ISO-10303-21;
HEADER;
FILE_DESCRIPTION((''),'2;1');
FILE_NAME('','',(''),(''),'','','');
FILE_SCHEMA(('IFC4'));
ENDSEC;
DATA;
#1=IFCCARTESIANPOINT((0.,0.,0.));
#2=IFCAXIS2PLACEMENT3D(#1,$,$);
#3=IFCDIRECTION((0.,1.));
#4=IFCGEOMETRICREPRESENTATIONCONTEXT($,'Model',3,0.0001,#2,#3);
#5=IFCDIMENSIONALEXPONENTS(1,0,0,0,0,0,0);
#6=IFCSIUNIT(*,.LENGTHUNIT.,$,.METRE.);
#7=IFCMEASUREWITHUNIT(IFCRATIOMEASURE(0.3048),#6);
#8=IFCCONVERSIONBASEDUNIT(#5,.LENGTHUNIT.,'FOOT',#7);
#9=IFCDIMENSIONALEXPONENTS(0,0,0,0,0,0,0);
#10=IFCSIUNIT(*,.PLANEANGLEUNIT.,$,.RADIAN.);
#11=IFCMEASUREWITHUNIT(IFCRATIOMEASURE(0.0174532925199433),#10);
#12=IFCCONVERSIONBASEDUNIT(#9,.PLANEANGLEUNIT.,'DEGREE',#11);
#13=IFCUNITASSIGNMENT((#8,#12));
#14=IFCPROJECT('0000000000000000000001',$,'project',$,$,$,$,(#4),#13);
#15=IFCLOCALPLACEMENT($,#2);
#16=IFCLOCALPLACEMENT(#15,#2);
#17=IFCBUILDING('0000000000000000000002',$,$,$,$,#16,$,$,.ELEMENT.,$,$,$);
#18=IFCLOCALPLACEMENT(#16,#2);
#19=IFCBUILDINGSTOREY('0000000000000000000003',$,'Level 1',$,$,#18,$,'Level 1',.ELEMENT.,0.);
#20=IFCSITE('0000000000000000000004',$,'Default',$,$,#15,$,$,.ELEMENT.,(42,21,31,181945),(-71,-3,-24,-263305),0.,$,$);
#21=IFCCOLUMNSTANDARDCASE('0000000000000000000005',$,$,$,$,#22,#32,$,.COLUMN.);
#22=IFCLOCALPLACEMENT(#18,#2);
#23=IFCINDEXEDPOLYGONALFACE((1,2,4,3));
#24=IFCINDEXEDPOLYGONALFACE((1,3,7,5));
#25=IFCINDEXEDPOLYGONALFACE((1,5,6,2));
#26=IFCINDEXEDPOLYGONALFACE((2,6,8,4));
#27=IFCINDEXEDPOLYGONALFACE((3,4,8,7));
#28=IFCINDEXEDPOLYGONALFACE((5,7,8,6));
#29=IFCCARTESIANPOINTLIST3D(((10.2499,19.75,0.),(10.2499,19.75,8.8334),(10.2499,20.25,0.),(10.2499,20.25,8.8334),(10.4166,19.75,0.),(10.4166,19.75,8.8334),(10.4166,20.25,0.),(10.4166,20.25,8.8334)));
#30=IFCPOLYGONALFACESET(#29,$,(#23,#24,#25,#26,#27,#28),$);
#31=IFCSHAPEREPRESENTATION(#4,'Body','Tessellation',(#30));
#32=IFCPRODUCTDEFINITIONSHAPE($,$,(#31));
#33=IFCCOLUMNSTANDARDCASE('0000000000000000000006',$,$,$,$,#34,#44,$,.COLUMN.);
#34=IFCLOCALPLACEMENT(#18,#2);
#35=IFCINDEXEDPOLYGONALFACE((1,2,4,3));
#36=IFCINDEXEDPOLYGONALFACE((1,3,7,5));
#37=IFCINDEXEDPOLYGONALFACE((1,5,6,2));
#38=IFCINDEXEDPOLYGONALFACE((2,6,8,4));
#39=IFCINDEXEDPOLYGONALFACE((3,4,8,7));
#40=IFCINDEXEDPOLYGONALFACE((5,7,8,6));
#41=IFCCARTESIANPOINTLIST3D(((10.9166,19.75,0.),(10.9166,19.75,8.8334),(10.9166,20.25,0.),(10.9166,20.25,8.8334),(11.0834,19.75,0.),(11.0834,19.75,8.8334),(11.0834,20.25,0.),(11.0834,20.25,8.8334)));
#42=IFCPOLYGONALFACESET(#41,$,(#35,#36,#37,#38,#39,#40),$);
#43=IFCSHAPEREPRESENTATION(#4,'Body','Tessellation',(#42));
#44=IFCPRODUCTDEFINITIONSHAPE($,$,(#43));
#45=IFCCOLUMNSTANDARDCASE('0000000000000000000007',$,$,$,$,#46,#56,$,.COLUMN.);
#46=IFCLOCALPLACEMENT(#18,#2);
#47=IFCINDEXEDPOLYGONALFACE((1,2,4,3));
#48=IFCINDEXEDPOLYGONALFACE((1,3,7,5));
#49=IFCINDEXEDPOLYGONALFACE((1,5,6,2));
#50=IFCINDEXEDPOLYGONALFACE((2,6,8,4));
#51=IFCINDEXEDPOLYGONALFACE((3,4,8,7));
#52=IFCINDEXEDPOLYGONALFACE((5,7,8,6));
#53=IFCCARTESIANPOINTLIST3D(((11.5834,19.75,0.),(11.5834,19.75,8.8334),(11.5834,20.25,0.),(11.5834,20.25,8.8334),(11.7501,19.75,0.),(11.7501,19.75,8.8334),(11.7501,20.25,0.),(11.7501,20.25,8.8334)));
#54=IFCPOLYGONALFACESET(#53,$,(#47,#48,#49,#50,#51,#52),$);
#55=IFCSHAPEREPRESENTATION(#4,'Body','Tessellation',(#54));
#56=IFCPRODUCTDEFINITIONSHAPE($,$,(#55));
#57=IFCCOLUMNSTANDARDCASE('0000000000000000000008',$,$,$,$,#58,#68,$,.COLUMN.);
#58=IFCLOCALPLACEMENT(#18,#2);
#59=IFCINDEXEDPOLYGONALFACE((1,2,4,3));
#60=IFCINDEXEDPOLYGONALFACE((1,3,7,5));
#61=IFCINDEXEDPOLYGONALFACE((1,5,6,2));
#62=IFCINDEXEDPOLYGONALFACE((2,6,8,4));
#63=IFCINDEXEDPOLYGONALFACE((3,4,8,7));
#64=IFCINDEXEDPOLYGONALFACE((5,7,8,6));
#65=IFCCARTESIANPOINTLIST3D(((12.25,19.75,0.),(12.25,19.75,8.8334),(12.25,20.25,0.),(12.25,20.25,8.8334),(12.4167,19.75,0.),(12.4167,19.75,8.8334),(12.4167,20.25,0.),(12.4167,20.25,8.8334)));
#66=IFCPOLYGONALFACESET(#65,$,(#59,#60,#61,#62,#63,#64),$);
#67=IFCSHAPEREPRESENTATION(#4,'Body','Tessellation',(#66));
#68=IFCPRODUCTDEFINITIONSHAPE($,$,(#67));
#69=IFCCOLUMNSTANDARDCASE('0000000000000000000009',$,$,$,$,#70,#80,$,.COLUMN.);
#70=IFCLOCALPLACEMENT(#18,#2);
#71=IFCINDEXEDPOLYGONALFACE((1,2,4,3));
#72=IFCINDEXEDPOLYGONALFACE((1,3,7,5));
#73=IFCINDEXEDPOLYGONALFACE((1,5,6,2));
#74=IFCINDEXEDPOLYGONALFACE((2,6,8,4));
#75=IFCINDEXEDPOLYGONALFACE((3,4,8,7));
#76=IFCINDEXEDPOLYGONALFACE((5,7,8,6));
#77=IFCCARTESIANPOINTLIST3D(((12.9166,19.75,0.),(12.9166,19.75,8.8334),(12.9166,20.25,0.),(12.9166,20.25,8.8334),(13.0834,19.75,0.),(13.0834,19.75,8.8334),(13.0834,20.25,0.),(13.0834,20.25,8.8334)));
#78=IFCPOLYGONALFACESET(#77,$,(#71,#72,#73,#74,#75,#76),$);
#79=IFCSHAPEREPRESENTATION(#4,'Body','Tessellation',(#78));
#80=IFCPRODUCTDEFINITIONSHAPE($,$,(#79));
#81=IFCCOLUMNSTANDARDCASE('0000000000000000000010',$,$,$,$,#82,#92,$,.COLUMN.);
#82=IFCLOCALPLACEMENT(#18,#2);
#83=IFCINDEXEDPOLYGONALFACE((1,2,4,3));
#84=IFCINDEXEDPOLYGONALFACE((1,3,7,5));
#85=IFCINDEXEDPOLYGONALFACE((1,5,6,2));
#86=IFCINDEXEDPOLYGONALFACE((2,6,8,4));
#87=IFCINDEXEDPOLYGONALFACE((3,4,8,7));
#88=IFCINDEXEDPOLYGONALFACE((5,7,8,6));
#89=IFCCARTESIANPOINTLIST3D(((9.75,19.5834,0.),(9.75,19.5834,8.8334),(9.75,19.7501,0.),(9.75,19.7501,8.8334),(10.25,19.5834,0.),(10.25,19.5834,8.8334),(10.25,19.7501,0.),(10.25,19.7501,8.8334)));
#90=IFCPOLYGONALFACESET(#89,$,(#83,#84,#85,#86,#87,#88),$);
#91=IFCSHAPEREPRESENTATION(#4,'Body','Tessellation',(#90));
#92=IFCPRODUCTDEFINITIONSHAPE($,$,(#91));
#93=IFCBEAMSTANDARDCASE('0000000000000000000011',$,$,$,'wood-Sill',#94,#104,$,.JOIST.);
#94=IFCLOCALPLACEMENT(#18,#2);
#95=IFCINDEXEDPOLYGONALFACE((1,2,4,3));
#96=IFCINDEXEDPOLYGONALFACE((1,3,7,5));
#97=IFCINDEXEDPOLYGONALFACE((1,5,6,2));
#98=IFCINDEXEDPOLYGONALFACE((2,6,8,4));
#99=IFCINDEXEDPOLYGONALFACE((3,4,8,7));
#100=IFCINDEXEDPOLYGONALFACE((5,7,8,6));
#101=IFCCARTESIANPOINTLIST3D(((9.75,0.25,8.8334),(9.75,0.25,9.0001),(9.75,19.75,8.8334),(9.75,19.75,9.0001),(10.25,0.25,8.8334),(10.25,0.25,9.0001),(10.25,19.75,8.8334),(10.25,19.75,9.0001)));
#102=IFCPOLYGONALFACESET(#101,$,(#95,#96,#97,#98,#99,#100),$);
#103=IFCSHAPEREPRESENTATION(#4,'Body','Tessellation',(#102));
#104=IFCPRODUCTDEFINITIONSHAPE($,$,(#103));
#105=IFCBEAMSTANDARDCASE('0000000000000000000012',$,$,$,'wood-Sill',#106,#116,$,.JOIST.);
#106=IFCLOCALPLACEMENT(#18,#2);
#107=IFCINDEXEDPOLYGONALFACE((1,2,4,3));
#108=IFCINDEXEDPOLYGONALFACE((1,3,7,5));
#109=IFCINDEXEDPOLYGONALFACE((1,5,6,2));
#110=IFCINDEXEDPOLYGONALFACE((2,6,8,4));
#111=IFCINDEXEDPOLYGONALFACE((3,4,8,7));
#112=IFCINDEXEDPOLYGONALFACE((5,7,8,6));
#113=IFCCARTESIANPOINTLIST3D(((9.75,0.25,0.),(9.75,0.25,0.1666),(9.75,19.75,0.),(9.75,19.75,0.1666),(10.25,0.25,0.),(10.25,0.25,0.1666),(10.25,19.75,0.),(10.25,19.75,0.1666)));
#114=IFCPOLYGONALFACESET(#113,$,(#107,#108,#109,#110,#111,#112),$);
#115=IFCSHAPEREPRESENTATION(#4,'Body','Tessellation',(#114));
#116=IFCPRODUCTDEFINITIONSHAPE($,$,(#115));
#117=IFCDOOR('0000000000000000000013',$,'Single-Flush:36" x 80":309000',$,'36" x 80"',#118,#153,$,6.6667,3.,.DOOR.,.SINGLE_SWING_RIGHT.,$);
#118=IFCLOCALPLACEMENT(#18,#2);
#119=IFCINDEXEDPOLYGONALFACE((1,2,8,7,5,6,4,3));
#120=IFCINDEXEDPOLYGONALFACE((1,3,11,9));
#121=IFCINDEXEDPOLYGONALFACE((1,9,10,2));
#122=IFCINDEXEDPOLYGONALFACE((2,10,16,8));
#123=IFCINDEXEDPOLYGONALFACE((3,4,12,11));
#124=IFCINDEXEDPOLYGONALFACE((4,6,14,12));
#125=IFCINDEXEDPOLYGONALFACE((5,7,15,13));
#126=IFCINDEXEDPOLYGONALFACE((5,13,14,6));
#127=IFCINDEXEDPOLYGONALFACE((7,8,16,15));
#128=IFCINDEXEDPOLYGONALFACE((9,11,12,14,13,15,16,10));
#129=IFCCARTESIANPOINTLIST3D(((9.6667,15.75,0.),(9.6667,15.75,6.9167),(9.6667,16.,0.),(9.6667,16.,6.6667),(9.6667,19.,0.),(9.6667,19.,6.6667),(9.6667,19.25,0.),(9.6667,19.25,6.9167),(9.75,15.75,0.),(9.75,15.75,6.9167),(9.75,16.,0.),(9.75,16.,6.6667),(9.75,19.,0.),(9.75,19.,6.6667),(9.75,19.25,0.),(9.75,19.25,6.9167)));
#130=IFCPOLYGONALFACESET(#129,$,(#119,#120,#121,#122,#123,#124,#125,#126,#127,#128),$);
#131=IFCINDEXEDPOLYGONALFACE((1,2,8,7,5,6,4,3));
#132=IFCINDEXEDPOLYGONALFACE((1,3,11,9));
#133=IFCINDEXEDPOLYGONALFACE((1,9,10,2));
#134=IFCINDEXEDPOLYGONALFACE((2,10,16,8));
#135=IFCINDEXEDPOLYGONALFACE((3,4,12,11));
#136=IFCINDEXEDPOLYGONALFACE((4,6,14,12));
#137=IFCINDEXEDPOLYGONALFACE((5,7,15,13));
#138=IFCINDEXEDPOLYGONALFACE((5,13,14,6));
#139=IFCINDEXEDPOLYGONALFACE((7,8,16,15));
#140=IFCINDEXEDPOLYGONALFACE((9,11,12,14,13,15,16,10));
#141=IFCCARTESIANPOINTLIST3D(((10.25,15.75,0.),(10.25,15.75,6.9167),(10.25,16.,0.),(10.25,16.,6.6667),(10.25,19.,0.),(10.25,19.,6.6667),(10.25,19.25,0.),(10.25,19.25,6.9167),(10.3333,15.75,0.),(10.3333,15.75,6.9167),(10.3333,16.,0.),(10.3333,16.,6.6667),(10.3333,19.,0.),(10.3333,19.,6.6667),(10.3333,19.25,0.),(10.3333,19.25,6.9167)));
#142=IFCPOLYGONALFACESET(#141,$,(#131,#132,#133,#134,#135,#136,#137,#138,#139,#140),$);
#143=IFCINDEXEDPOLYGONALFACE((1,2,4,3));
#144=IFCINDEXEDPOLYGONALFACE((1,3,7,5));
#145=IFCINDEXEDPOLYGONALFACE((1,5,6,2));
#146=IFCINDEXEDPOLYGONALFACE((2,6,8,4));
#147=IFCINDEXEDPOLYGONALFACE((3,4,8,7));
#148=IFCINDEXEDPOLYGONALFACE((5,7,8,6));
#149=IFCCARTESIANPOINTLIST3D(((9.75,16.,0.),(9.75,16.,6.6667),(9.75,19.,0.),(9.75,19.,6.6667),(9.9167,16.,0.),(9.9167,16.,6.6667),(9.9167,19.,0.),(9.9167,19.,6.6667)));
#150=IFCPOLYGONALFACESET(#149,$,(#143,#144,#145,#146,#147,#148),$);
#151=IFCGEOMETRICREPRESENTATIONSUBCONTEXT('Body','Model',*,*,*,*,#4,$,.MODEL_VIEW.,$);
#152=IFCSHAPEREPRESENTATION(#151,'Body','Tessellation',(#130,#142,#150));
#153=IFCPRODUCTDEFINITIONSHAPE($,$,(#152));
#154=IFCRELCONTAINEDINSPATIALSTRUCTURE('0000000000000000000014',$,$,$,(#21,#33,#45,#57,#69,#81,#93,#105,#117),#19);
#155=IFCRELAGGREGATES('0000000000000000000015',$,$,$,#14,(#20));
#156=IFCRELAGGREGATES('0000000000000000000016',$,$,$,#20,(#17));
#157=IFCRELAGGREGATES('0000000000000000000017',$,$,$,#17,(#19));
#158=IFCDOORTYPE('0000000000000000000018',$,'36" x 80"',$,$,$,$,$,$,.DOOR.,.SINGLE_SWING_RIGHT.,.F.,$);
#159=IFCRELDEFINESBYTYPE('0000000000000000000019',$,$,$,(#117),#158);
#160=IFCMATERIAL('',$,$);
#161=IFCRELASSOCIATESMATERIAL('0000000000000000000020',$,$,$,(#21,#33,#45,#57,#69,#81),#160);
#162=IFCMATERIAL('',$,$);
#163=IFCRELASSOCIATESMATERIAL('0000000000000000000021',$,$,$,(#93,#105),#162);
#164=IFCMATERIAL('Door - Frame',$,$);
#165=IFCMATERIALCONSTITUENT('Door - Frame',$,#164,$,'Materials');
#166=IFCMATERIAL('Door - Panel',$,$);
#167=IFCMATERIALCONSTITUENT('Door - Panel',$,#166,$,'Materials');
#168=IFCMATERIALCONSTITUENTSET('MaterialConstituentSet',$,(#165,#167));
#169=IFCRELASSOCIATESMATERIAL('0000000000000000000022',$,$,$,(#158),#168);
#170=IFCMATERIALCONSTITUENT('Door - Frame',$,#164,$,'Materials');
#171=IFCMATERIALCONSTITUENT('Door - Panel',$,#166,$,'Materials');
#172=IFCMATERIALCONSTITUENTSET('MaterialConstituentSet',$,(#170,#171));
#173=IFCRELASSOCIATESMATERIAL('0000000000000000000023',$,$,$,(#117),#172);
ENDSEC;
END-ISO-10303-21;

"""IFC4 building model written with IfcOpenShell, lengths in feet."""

from ifc_helpers import new_model, entity, si_unit, converted_unit, direction, frame, origin, origin_with_axes, origin_2d_with_axis, place, context, subcontext, project, spatial, polyline, rectangle, outline, extrude, source, transform, mapped, material, constituent, constituent_set, type_object, type_shapes, element, save


model = new_model("IFC4")

# Units and contexts
model_context = context("Model", 3, precision=0.0001, world=origin(), true_north=direction((0.0, 1.0)))
body_context = subcontext(model_context, "Body", "Model", "MODEL_VIEW")
ifc_project = project(units=[converted_unit("LENGTHUNIT", "FOOT", entity("IfcRatioMeasure", 0.3048), si_unit("LENGTHUNIT", "METRE"), dimensions=[1, 0, 0, 0, 0, 0, 0]), converted_unit("PLANEANGLEUNIT", "DEGREE", entity("IfcRatioMeasure", 0.0174532925199433), si_unit("PLANEANGLEUNIT", "RADIAN"), dimensions=[0, 0, 0, 0, 0, 0, 0])], contexts=[model_context])

# Site, building, storey
site_placement = place(None, origin())
site = spatial("IfcSite", under=ifc_project, at=site_placement, Name="Default", CompositionType="ELEMENT", RefLatitude=(42, 21, 31, 181945), RefLongitude=(-71, -3, -24, -263305), RefElevation=0.0)
building_placement = place(site_placement, origin())
building = spatial("IfcBuilding", under=site, at=building_placement, CompositionType="ELEMENT")
storey_placement = place(building_placement, origin())
storey = spatial("IfcBuildingStorey", under=building, at=storey_placement, Name="Level 1", LongName="Level 1", CompositionType="ELEMENT", Elevation=0.0)

# Columns
ifc_material_1 = material(Name="")
placement_1 = place(storey_placement, frame((0.25, 20.0, 0.0)))
for number, where, z_axis, x_axis in (
    (1, (10.0833, 0.0, 0.0), (0.0, 0.0, 1.0), (1.0, 0.0, 0.0)),
    (2, (10.75, 0.0, 0.0), (0.0, 0.0, 1.0), (1.0, 0.0, 0.0)),
    (3, (11.4167, 0.0, 0.0), (0.0, 0.0, 1.0), (1.0, 0.0, 0.0)),
    (4, (12.0834, 0.0, 0.0), (0.0, 0.0, 1.0), (1.0, 0.0, 0.0)),
    (5, (12.75, 0.0, 0.0), (0.0, 0.0, 1.0), (1.0, 0.0, 0.0)),
):
    element("IfcColumnStandardCase", number, at=place(placement_1, frame(where, z_axis=z_axis, x_axis=x_axis)), inside=storey, material=ifc_material_1, PredefinedType="COLUMN", context=model_context, shape_type="SweptSolid", body=[
        extrude(rectangle(XDim=0.1667, YDim=0.5), origin(), (0.0, 0.0, 1.0), 8.8334),
    ])
placement_2 = place(storey_placement, frame((10.0, 19.75, 0.0), z_axis=(0.0, 0.0, 1.0), x_axis=(0.0, -1.0, 0.0)))
for number, where, z_axis, x_axis in (
    (6, (0.0833, 0.0, 0.0), (0.0, 0.0, 1.0), (1.0, 0.0, 0.0)),
):
    element("IfcColumnStandardCase", number, at=place(placement_2, frame(where, z_axis=z_axis, x_axis=x_axis)), inside=storey, material=ifc_material_1, PredefinedType="COLUMN", context=model_context, shape_type="SweptSolid", body=[
        extrude(rectangle(XDim=0.1667, YDim=0.5), origin(), (0.0, 0.0, 1.0), 8.8334),
    ])

# Beams
ifc_material_2 = material(Name="")
for number, where, z_axis, x_axis in (
    (7, (0.0, 0.0, 8.9167), (1.0, 0.0, 0.0), (0.0, 0.0, 1.0)),
    (8, (0.0, 0.0, 0.0833), (1.0, 0.0, 0.0), (0.0, 0.0, 1.0)),
):
    element("IfcBeamStandardCase", number, at=place(placement_2, frame(where, z_axis=z_axis, x_axis=x_axis)), inside=storey, material=ifc_material_2, ObjectType="wood-Sill", PredefinedType="JOIST", context=model_context, shape_type="SweptSolid", body=[
        extrude(rectangle(XDim=0.1667, YDim=0.5), origin_with_axes(), (0.0, 0.0, 1.0), 19.5),
    ])

# Door
ifc_material_3 = material(Name="Door - Frame")
ifc_constituent_1 = constituent(ifc_material_3, Name="Door - Frame", Category="Materials")
ifc_material_4 = material(Name="Door - Panel")
ifc_constituent_2 = constituent(ifc_material_4, Name="Door - Panel", Category="Materials")
ifc_constituent_set_1 = constituent_set(constituents=[ifc_constituent_1, ifc_constituent_2], Name="MaterialConstituentSet")
ifc_constituent_3 = constituent(ifc_material_3, Name="Door - Frame", Category="Materials")
ifc_constituent_4 = constituent(ifc_material_4, Name="Door - Panel", Category="Materials")
ifc_constituent_set_2 = constituent_set(constituents=[ifc_constituent_3, ifc_constituent_4], Name="MaterialConstituentSet")
door_type = type_object("IfcDoorType", Name="36\" x 80\"", OperationType="SINGLE_SWING_RIGHT", ParameterTakesPrecedence=False, PredefinedType="DOOR", material=ifc_constituent_set_2)
shared_shape = source(origin(), body_context, "Body", "SweptSolid", [
    extrude(outline(polyline([(-1.75, -3.5208), (1.75, -3.5208), (1.75, 3.3958), (1.5, 3.3958), (1.5, -3.2708), (-1.5, -3.2708), (-1.5, 3.3958), (-1.75, 3.3958), (-1.75, -3.5208)])), frame((1.5, 0.5, 3.3958), z_axis=(0.0, 1.0, 0.0), x_axis=(1.0, 0.0, 0.0)), (0.0, 0.0, 1.0), 0.0833),
    extrude(outline(polyline([(-3.5208, -1.75), (3.3958, -1.75), (3.3958, -1.5), (-3.2708, -1.5), (-3.2708, 1.5), (3.3958, 1.5), (3.3958, 1.75), (-3.5208, 1.75), (-3.5208, -1.75)])), frame((1.5, -0.0833, 3.3958), z_axis=(0.0, 1.0, 0.0), x_axis=(0.0, 0.0, -1.0)), (0.0, 0.0, 1.0), 0.0833),
    extrude(rectangle(XDim=0.1667, YDim=3.0, at=origin_2d_with_axis()), frame((1.5, 0.4167, 0.0), z_axis=(0.0, 0.0, 1.0), x_axis=(0.0, 1.0, 0.0)), (0.0, 0.0, 1.0), 6.6667),
])
type_shapes(door_type, [shared_shape])
placement_3 = place(placement_2, frame((3.75, 0.25, 0.0)))
door_placement = place(placement_3, frame((0.0, 0.0, 0.0), z_axis=(0.0, 0.0, 1.0), x_axis=(-1.0, 0.0, 0.0)))
element("IfcDoor", 9, at=door_placement, inside=storey, type_object=door_type, material=ifc_constituent_set_1, Name="Single-Flush:36\" x 80\":309000", ObjectType="36\" x 80\"", OperationType="SINGLE_SWING_RIGHT", OverallHeight=6.6667, OverallWidth=3.0, PredefinedType="DOOR", context=body_context, shape_type="MappedRepresentation", body=[
    mapped(shared_shape, transform((0.0, 0.0, 0.0), scale=1.0)),
])

save(model, "model.ifc")
